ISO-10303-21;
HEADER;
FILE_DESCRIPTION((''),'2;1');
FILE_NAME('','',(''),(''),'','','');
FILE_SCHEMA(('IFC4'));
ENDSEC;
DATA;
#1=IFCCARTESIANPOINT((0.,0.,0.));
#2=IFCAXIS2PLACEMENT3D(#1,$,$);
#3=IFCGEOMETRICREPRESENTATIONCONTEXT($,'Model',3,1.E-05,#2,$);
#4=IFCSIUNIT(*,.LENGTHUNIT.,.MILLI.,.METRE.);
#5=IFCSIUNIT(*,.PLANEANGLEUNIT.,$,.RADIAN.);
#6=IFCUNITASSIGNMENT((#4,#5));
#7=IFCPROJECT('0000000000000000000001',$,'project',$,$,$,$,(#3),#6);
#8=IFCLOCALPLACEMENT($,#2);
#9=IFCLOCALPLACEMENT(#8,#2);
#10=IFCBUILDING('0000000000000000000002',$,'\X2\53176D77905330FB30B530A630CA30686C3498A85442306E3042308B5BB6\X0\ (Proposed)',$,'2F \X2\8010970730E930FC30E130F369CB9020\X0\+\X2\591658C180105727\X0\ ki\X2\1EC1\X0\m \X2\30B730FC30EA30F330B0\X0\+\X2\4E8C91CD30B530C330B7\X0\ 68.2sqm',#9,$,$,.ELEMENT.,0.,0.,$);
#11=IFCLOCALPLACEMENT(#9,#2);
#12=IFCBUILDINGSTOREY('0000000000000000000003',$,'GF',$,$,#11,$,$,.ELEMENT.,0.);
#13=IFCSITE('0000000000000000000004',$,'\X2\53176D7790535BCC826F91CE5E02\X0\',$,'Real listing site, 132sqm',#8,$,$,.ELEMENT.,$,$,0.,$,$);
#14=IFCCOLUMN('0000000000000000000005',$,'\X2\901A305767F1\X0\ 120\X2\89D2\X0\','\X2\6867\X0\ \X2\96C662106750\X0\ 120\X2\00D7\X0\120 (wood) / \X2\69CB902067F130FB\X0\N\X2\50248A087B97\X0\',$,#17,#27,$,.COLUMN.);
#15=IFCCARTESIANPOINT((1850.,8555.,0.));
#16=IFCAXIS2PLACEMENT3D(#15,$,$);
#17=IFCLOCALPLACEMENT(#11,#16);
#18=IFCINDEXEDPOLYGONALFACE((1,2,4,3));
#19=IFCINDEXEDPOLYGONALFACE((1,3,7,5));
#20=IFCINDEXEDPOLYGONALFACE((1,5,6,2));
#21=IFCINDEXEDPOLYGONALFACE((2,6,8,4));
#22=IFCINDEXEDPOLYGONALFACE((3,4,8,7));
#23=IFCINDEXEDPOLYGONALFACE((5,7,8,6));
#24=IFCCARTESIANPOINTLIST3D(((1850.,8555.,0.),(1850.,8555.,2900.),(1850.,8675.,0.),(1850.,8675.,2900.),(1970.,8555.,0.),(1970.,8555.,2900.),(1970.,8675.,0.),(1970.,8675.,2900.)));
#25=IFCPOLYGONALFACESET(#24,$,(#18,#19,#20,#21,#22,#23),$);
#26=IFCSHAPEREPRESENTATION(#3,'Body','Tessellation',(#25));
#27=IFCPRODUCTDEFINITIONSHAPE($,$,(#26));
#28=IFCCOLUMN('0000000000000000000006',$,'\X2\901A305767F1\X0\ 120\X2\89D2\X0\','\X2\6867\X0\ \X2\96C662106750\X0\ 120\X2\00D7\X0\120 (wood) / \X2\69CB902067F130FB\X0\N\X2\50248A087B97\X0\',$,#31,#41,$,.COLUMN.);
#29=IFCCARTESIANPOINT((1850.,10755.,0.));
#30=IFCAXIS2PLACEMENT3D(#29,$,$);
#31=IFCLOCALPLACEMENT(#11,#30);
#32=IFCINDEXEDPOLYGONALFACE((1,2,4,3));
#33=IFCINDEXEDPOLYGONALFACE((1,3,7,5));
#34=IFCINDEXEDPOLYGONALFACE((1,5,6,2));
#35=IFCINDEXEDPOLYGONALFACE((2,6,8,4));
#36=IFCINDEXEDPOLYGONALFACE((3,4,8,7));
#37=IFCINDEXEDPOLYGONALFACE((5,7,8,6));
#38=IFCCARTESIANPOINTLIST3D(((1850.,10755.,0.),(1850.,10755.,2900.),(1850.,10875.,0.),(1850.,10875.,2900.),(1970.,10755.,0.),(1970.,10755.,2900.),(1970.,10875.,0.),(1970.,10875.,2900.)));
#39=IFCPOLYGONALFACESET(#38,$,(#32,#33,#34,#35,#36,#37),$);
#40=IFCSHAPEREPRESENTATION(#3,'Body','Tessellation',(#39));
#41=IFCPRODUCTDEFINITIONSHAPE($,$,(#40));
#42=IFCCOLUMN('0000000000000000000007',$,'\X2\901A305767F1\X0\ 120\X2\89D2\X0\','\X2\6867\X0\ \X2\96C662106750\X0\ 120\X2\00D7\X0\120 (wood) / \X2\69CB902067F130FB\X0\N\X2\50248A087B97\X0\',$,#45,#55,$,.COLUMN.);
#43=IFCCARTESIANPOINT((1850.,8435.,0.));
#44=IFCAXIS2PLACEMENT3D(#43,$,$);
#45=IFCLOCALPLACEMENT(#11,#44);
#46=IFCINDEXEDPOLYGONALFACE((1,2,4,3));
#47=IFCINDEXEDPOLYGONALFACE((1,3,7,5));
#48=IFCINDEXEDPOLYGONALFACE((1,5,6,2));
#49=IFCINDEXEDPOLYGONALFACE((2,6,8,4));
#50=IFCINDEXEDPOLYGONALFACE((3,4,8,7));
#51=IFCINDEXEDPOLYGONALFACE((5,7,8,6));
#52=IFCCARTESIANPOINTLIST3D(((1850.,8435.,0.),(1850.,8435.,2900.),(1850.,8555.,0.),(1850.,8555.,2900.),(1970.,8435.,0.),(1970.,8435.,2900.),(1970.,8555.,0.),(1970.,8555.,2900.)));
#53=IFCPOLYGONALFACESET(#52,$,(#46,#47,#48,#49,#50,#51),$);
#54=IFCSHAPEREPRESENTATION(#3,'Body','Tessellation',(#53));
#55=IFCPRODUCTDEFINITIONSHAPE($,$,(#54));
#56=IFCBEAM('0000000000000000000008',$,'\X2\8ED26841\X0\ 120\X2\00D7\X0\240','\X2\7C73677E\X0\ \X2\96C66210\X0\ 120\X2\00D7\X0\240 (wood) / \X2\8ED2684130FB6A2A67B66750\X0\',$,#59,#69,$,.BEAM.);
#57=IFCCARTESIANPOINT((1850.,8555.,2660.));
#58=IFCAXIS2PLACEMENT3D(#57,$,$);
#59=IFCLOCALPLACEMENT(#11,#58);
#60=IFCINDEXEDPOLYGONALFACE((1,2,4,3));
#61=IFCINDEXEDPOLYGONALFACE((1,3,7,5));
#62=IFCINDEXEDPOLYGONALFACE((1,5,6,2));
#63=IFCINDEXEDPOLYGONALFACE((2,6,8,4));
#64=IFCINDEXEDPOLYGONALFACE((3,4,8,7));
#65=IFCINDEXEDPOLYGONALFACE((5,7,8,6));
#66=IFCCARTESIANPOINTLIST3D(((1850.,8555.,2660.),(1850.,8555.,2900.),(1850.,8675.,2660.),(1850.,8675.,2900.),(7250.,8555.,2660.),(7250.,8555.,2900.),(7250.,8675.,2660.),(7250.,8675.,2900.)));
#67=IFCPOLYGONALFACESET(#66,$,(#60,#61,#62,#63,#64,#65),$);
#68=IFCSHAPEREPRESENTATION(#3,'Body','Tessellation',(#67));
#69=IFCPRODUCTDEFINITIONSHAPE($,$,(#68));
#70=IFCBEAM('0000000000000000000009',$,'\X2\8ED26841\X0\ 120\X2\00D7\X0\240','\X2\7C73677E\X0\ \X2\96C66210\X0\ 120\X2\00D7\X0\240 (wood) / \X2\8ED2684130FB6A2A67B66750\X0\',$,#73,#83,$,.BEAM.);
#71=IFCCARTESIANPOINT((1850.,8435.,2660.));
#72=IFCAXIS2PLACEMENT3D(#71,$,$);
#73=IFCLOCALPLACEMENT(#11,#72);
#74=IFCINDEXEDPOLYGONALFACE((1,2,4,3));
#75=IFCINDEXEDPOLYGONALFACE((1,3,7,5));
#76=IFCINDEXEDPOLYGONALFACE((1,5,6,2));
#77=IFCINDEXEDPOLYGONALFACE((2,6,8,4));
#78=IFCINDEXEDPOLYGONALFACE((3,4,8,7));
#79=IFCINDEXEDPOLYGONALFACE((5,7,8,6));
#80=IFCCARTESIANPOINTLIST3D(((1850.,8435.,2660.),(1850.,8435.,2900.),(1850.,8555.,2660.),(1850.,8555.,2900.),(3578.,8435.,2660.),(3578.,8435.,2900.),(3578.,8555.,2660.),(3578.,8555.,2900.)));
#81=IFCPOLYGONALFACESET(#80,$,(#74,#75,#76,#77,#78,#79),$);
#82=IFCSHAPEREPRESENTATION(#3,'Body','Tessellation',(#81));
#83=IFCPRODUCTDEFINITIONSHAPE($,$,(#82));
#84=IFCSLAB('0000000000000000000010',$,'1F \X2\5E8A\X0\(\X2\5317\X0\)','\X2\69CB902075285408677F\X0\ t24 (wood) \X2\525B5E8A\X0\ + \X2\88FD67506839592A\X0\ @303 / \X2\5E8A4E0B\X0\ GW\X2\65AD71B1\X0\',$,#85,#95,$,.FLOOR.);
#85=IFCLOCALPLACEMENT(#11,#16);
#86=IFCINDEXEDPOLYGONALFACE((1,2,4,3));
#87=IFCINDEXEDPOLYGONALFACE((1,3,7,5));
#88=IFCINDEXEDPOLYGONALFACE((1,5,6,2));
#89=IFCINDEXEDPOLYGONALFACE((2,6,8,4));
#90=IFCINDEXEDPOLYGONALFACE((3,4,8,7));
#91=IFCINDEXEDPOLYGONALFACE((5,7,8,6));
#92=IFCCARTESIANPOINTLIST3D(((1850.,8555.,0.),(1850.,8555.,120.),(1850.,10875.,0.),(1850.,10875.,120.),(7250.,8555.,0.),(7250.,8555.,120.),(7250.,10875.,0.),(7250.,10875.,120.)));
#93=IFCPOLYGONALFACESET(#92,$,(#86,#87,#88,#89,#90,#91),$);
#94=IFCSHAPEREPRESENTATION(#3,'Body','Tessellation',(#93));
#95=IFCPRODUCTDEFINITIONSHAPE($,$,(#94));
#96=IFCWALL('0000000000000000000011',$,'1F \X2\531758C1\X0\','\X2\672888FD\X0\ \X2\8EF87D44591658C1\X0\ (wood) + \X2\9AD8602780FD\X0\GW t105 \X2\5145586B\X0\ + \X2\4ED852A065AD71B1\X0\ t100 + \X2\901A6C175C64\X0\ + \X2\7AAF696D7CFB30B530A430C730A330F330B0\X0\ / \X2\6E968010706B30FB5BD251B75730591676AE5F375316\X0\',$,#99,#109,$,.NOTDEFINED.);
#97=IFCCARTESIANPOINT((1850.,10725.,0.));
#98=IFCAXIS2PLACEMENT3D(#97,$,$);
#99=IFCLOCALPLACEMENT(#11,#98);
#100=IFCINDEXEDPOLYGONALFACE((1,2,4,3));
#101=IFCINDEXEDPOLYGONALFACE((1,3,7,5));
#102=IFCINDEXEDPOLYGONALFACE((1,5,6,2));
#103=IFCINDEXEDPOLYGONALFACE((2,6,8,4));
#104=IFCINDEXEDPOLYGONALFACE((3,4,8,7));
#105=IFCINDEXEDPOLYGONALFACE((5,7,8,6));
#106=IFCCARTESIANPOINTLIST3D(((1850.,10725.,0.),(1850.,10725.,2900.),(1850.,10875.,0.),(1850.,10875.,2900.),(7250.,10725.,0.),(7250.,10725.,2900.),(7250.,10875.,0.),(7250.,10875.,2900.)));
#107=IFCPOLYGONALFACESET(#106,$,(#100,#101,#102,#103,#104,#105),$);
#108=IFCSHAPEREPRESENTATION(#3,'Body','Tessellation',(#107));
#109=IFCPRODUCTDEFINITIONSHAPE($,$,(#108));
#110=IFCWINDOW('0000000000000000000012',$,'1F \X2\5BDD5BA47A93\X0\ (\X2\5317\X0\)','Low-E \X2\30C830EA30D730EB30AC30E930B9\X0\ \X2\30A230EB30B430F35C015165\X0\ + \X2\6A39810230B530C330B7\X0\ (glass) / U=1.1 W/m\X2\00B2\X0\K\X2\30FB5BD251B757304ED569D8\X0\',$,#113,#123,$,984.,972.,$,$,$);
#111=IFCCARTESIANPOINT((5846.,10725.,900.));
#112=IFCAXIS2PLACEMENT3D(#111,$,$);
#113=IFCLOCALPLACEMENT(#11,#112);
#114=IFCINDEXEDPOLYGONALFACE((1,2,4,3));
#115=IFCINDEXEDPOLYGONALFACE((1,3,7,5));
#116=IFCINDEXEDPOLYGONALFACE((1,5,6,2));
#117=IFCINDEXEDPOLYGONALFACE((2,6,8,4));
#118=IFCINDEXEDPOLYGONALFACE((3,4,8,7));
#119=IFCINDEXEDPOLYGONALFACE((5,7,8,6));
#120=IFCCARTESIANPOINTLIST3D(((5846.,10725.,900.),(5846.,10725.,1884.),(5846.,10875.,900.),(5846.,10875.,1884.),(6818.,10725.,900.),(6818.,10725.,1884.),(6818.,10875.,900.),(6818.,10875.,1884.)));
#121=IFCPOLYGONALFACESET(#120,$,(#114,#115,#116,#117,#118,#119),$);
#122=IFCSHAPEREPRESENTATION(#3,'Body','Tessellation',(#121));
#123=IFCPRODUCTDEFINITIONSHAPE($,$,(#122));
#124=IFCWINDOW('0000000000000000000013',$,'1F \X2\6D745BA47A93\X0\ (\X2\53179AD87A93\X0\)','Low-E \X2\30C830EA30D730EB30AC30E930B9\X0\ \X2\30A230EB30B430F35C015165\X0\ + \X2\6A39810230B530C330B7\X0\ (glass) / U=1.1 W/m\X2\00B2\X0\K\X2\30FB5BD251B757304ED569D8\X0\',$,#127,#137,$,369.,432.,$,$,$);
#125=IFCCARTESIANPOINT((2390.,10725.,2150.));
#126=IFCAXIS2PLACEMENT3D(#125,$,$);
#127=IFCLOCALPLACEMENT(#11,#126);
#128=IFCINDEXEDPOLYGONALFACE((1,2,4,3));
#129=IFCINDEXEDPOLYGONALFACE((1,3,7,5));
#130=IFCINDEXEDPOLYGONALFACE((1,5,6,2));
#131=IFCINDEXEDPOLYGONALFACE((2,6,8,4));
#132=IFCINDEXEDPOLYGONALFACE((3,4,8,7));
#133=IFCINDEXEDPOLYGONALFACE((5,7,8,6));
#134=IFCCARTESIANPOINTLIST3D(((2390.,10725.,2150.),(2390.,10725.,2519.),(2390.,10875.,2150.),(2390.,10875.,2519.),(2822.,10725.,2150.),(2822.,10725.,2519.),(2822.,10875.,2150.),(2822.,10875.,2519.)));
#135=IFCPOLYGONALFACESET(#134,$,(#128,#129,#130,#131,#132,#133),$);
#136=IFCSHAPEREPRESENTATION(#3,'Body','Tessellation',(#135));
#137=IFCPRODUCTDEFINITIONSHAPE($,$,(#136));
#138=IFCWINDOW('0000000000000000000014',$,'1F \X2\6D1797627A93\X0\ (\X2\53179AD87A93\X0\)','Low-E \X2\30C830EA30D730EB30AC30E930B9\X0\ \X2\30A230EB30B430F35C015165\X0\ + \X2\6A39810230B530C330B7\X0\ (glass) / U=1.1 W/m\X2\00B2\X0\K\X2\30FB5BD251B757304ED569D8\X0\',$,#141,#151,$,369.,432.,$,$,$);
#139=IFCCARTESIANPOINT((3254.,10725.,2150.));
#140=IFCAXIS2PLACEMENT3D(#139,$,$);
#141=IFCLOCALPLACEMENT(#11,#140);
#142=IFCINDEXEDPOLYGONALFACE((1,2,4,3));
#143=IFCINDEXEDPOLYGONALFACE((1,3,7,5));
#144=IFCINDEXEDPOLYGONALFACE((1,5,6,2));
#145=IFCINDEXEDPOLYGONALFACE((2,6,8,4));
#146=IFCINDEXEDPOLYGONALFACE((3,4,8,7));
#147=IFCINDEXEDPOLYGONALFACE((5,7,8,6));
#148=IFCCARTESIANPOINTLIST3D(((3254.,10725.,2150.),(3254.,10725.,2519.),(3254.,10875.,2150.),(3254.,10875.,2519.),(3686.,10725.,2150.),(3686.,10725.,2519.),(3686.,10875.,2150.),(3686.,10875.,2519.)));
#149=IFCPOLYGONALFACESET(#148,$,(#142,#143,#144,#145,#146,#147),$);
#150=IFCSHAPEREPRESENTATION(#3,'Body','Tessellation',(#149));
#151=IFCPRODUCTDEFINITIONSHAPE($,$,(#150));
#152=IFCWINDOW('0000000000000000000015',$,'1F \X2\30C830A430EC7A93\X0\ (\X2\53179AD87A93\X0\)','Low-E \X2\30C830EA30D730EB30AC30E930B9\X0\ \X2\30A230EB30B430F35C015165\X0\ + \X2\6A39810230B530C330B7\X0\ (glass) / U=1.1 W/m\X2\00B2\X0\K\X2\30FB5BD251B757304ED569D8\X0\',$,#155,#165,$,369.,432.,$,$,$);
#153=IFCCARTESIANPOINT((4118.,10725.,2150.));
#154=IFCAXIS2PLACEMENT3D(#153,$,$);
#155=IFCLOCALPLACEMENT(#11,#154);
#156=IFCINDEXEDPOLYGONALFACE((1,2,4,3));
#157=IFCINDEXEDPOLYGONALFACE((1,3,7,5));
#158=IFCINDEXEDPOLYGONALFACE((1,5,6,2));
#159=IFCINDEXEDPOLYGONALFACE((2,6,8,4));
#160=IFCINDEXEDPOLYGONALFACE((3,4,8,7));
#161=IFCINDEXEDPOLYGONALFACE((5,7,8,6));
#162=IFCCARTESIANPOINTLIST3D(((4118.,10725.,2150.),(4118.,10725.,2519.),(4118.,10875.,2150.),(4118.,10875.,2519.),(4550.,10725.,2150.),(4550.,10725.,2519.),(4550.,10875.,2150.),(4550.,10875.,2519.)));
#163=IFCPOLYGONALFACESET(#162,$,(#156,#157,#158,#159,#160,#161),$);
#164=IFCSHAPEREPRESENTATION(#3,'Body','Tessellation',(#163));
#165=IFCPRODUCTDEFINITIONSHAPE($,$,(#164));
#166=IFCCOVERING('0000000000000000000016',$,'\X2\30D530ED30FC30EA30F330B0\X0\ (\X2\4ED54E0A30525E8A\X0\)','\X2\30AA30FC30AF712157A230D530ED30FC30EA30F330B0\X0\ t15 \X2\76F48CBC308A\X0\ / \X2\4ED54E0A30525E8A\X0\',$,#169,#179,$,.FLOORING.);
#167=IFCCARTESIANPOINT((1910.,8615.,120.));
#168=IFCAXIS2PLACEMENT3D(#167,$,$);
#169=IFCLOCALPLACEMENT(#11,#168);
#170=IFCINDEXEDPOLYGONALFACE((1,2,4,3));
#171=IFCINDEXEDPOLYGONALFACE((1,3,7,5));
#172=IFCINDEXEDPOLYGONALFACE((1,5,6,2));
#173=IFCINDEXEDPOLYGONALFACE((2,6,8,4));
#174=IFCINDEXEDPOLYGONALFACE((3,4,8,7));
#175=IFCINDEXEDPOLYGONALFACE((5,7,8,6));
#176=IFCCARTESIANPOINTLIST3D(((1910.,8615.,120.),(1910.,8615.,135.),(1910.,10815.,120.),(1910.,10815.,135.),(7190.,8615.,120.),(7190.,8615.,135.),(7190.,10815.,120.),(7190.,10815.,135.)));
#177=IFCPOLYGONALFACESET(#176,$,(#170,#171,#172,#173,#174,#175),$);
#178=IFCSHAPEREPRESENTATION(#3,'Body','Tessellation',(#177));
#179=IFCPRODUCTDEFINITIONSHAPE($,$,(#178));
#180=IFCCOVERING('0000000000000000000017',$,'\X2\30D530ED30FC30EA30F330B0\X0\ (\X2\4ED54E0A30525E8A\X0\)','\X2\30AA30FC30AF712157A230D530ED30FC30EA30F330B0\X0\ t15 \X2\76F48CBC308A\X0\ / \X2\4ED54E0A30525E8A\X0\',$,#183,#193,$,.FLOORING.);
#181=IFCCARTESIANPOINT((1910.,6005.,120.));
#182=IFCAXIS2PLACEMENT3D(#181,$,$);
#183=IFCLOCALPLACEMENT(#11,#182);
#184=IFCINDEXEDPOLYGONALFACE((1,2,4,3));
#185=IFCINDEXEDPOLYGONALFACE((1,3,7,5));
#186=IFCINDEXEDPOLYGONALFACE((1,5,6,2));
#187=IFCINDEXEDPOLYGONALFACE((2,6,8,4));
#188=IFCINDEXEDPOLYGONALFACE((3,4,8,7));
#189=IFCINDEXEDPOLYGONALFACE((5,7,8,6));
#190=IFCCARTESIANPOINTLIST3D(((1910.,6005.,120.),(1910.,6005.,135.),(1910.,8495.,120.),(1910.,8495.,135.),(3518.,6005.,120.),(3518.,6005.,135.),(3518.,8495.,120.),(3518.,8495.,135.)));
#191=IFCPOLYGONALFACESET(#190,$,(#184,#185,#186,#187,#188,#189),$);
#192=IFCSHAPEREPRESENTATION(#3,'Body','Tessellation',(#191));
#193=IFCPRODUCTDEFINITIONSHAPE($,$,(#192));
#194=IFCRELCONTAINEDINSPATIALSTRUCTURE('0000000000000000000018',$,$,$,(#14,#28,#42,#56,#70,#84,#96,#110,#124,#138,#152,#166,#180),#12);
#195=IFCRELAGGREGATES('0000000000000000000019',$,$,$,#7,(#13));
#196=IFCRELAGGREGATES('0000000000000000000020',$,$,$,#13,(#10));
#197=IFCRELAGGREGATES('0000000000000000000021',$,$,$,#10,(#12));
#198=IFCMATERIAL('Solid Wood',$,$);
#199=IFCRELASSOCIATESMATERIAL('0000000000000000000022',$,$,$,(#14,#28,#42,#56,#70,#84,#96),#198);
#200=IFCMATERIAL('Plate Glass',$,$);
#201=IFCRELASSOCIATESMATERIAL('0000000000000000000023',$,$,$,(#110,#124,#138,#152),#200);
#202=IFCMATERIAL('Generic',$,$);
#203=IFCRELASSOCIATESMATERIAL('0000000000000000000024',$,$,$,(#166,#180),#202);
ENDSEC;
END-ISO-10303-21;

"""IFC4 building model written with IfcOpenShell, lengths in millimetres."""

from ifc_helpers import new_model, si_unit, frame, frame_2d, origin, place, context, project, spatial, rectangle, extrude, material, element, fill, save


model = new_model("IFC4")

# Units and contexts
model_context = context("Model", 3, precision=1e-05, world=origin())
ifc_project = project(units=[si_unit("LENGTHUNIT", "METRE", prefix="MILLI"), si_unit("PLANEANGLEUNIT", "RADIAN")], contexts=[model_context])

# Site, building, storey
site_placement = place(None, origin())
site = spatial("IfcSite", under=ifc_project, at=site_placement, Name="北海道富良野市", ObjectType="Real listing site, 132sqm", CompositionType="ELEMENT", RefElevation=0.0)
building_placement = place(site_placement, origin())
building = spatial("IfcBuilding", under=site, at=building_placement, Name="北海道・サウナと水風呂のある家 (Proposed)", ObjectType="2F 耐震ラーメン構造+外壁耐圧 kiềm シーリング+二重サッシ 68.2sqm", CompositionType="ELEMENT", ElevationOfRefHeight=0.0, ElevationOfTerrain=0.0)
storey_placement = place(building_placement, origin())
storey = spatial("IfcBuildingStorey", under=building, at=storey_placement, Name="GF", CompositionType="ELEMENT", Elevation=0.0)

# Columns
ifc_material_1 = material(Name="Solid Wood")
column_1_placement = place(storey_placement, frame((1850.0, 8555.0, 0.0)))
element("IfcColumn", 1, at=column_1_placement, inside=storey, material=ifc_material_1, Name="通し柱 120角", Description="桧 集成材 120×120 (wood) / 構造柱・N値計算", PredefinedType="COLUMN", context=model_context, shape_type="SweptSolid", body=[
    extrude(rectangle(XDim=120.0, YDim=120.0, at=frame_2d((60.0, 60.0))), frame((1850.0, 8555.0, 0.0)), (0.0, 0.0, 1.0), 2900.0),
])
column_2_placement = place(storey_placement, frame((1850.0, 10755.0, 0.0)))
element("IfcColumn", 2, at=column_2_placement, inside=storey, material=ifc_material_1, Name="通し柱 120角", Description="桧 集成材 120×120 (wood) / 構造柱・N値計算", PredefinedType="COLUMN", context=model_context, shape_type="SweptSolid", body=[
    extrude(rectangle(XDim=120.0, YDim=120.0, at=frame_2d((60.0, 60.0))), frame((1850.0, 10755.0, 0.0)), (0.0, 0.0, 1.0), 2900.0),
])
column_3_placement = place(storey_placement, frame((1850.0, 8435.0, 0.0)))
element("IfcColumn", 3, at=column_3_placement, inside=storey, material=ifc_material_1, Name="通し柱 120角", Description="桧 集成材 120×120 (wood) / 構造柱・N値計算", PredefinedType="COLUMN", context=model_context, shape_type="SweptSolid", body=[
    extrude(rectangle(XDim=120.0, YDim=120.0, at=frame_2d((60.0, 60.0))), frame((1850.0, 8435.0, 0.0)), (0.0, 0.0, 1.0), 2900.0),
])

# Beams
beam_1_placement = place(storey_placement, frame((1850.0, 8555.0, 2660.0)))
element("IfcBeam", 4, at=beam_1_placement, inside=storey, material=ifc_material_1, Name="軒桁 120×240", Description="米松 集成 120×240 (wood) / 軒桁・横架材", PredefinedType="BEAM", context=model_context, shape_type="SweptSolid", body=[
    extrude(rectangle(XDim=5400.0, YDim=120.0, at=frame_2d((2700.0, 60.0))), frame((1850.0, 8555.0, 2660.0)), (0.0, 0.0, 1.0), 240.0),
])
beam_2_placement = place(storey_placement, frame((1850.0, 8435.0, 2660.0)))
element("IfcBeam", 5, at=beam_2_placement, inside=storey, material=ifc_material_1, Name="軒桁 120×240", Description="米松 集成 120×240 (wood) / 軒桁・横架材", PredefinedType="BEAM", context=model_context, shape_type="SweptSolid", body=[
    extrude(rectangle(XDim=1728.0, YDim=120.0, at=frame_2d((864.0, 60.0))), frame((1850.0, 8435.0, 2660.0)), (0.0, 0.0, 1.0), 240.0),
])

# Slab
slab_placement = place(storey_placement, frame((1850.0, 8555.0, 0.0)))
element("IfcSlab", 6, at=slab_placement, inside=storey, material=ifc_material_1, Name="1F 床(北)", Description="構造用合板 t24 (wood) 剛床 + 製材根太 @303 / 床下 GW断熱", PredefinedType="FLOOR", context=model_context, shape_type="SweptSolid", body=[
    extrude(rectangle(XDim=5400.0, YDim=2320.0, at=frame_2d((2700.0, 1160.0))), frame((1850.0, 8555.0, 0.0)), (0.0, 0.0, 1.0), 120.0),
])

# Wall, openings, windows
wall_1_placement = place(storey_placement, frame((1850.0, 10725.0, 0.0)))
wall_1 = element("IfcWall", 7, at=wall_1_placement, inside=storey, material=ifc_material_1, Name="1F 北壁", Description="木製 軸組外壁 (wood) + 高性能GW t105 充填 + 付加断熱 t100 + 通気層 + 窯業系サイディング / 準耐火・寒冷地外皮強化", PredefinedType="NOTDEFINED", context=model_context, shape_type="SweptSolid", body=[
    extrude(rectangle(XDim=5400.0, YDim=150.0, at=frame_2d((2700.0, 75.0))), frame((1850.0, 10725.0, 0.0)), (0.0, 0.0, 1.0), 2900.0),
])
opening_1_placement = place(storey_placement, frame((5846.0, 10725.0, 900.0)))
opening_1 = element("IfcOpeningElement", 8, at=opening_1_placement, cuts=wall_1, PredefinedType="NOTDEFINED", context=model_context, shape_type="SweptSolid", body=[
    extrude(rectangle(XDim=972.0, YDim=150.0, at=frame_2d((486.0, 75.0))), frame((5846.0, 10725.0, 900.0)), (0.0, 0.0, 1.0), 984.0),
])
opening_2_placement = place(storey_placement, frame((2390.0, 10725.0, 2150.0)))
opening_2 = element("IfcOpeningElement", 9, at=opening_2_placement, cuts=wall_1, PredefinedType="NOTDEFINED", context=model_context, shape_type="SweptSolid", body=[
    extrude(rectangle(XDim=432.0, YDim=150.0, at=frame_2d((216.0, 75.0))), frame((2390.0, 10725.0, 2150.0)), (0.0, 0.0, 1.0), 369.0),
])
opening_3_placement = place(storey_placement, frame((3254.0, 10725.0, 2150.0)))
opening_3 = element("IfcOpeningElement", 10, at=opening_3_placement, cuts=wall_1, PredefinedType="NOTDEFINED", context=model_context, shape_type="SweptSolid", body=[
    extrude(rectangle(XDim=432.0, YDim=150.0, at=frame_2d((216.0, 75.0))), frame((3254.0, 10725.0, 2150.0)), (0.0, 0.0, 1.0), 369.0),
])
opening_4_placement = place(storey_placement, frame((4118.0, 10725.0, 2150.0)))
opening_4 = element("IfcOpeningElement", 11, at=opening_4_placement, cuts=wall_1, PredefinedType="NOTDEFINED", context=model_context, shape_type="SweptSolid", body=[
    extrude(rectangle(XDim=432.0, YDim=150.0, at=frame_2d((216.0, 75.0))), frame((4118.0, 10725.0, 2150.0)), (0.0, 0.0, 1.0), 369.0),
])
ifc_material_2 = material(Name="Plate Glass")
window_1_placement = place(storey_placement, frame((5846.0, 10725.0, 900.0)))
window_1 = element("IfcWindow", 12, at=window_1_placement, inside=storey, material=ifc_material_2, Name="1F 寝室窓 (北)", Description="Low-E トリプルガラス アルゴン封入 + 樹脂サッシ (glass) / U=1.1 W/m²K・寒冷地仕様", OverallHeight=984.0, OverallWidth=972.0, context=model_context, shape_type="SweptSolid", body=[
    extrude(rectangle(XDim=972.0, YDim=150.0, at=frame_2d((486.0, 75.0))), frame((5846.0, 10725.0, 900.0)), (0.0, 0.0, 1.0), 984.0),
])
fill(opening_1, window_1)
window_2_placement = place(storey_placement, frame((2390.0, 10725.0, 2150.0)))
window_2 = element("IfcWindow", 13, at=window_2_placement, inside=storey, material=ifc_material_2, Name="1F 浴室窓 (北高窓)", Description="Low-E トリプルガラス アルゴン封入 + 樹脂サッシ (glass) / U=1.1 W/m²K・寒冷地仕様", OverallHeight=369.0, OverallWidth=432.0, context=model_context, shape_type="SweptSolid", body=[
    extrude(rectangle(XDim=432.0, YDim=150.0, at=frame_2d((216.0, 75.0))), frame((2390.0, 10725.0, 2150.0)), (0.0, 0.0, 1.0), 369.0),
])
fill(opening_2, window_2)
window_3_placement = place(storey_placement, frame((3254.0, 10725.0, 2150.0)))
window_3 = element("IfcWindow", 14, at=window_3_placement, inside=storey, material=ifc_material_2, Name="1F 洗面窓 (北高窓)", Description="Low-E トリプルガラス アルゴン封入 + 樹脂サッシ (glass) / U=1.1 W/m²K・寒冷地仕様", OverallHeight=369.0, OverallWidth=432.0, context=model_context, shape_type="SweptSolid", body=[
    extrude(rectangle(XDim=432.0, YDim=150.0, at=frame_2d((216.0, 75.0))), frame((3254.0, 10725.0, 2150.0)), (0.0, 0.0, 1.0), 369.0),
])
fill(opening_3, window_3)
window_4_placement = place(storey_placement, frame((4118.0, 10725.0, 2150.0)))
window_4 = element("IfcWindow", 15, at=window_4_placement, inside=storey, material=ifc_material_2, Name="1F トイレ窓 (北高窓)", Description="Low-E トリプルガラス アルゴン封入 + 樹脂サッシ (glass) / U=1.1 W/m²K・寒冷地仕様", OverallHeight=369.0, OverallWidth=432.0, context=model_context, shape_type="SweptSolid", body=[
    extrude(rectangle(XDim=432.0, YDim=150.0, at=frame_2d((216.0, 75.0))), frame((4118.0, 10725.0, 2150.0)), (0.0, 0.0, 1.0), 369.0),
])
fill(opening_4, window_4)

# Coverings
ifc_material_3 = material(Name="Generic")
covering_1_placement = place(storey_placement, frame((1910.0, 8615.0, 120.0)))
element("IfcCovering", 16, at=covering_1_placement, inside=storey, material=ifc_material_3, Name="フローリング (仕上げ床)", Description="オーク無垢フローリング t15 直貼り / 仕上げ床", PredefinedType="FLOORING", context=model_context, shape_type="SweptSolid", body=[
    extrude(rectangle(XDim=5280.0, YDim=2200.0, at=frame_2d((2640.0, 1100.0))), frame((1910.0, 8615.0, 120.0)), (0.0, 0.0, 1.0), 15.0),
])
covering_2_placement = place(storey_placement, frame((1910.0, 6005.0, 120.0)))
element("IfcCovering", 17, at=covering_2_placement, inside=storey, material=ifc_material_3, Name="フローリング (仕上げ床)", Description="オーク無垢フローリング t15 直貼り / 仕上げ床", PredefinedType="FLOORING", context=model_context, shape_type="SweptSolid", body=[
    extrude(rectangle(XDim=1608.0, YDim=2490.0, at=frame_2d((804.0, 1245.0))), frame((1910.0, 6005.0, 120.0)), (0.0, 0.0, 1.0), 15.0),
])

save(model, "model.ifc")
